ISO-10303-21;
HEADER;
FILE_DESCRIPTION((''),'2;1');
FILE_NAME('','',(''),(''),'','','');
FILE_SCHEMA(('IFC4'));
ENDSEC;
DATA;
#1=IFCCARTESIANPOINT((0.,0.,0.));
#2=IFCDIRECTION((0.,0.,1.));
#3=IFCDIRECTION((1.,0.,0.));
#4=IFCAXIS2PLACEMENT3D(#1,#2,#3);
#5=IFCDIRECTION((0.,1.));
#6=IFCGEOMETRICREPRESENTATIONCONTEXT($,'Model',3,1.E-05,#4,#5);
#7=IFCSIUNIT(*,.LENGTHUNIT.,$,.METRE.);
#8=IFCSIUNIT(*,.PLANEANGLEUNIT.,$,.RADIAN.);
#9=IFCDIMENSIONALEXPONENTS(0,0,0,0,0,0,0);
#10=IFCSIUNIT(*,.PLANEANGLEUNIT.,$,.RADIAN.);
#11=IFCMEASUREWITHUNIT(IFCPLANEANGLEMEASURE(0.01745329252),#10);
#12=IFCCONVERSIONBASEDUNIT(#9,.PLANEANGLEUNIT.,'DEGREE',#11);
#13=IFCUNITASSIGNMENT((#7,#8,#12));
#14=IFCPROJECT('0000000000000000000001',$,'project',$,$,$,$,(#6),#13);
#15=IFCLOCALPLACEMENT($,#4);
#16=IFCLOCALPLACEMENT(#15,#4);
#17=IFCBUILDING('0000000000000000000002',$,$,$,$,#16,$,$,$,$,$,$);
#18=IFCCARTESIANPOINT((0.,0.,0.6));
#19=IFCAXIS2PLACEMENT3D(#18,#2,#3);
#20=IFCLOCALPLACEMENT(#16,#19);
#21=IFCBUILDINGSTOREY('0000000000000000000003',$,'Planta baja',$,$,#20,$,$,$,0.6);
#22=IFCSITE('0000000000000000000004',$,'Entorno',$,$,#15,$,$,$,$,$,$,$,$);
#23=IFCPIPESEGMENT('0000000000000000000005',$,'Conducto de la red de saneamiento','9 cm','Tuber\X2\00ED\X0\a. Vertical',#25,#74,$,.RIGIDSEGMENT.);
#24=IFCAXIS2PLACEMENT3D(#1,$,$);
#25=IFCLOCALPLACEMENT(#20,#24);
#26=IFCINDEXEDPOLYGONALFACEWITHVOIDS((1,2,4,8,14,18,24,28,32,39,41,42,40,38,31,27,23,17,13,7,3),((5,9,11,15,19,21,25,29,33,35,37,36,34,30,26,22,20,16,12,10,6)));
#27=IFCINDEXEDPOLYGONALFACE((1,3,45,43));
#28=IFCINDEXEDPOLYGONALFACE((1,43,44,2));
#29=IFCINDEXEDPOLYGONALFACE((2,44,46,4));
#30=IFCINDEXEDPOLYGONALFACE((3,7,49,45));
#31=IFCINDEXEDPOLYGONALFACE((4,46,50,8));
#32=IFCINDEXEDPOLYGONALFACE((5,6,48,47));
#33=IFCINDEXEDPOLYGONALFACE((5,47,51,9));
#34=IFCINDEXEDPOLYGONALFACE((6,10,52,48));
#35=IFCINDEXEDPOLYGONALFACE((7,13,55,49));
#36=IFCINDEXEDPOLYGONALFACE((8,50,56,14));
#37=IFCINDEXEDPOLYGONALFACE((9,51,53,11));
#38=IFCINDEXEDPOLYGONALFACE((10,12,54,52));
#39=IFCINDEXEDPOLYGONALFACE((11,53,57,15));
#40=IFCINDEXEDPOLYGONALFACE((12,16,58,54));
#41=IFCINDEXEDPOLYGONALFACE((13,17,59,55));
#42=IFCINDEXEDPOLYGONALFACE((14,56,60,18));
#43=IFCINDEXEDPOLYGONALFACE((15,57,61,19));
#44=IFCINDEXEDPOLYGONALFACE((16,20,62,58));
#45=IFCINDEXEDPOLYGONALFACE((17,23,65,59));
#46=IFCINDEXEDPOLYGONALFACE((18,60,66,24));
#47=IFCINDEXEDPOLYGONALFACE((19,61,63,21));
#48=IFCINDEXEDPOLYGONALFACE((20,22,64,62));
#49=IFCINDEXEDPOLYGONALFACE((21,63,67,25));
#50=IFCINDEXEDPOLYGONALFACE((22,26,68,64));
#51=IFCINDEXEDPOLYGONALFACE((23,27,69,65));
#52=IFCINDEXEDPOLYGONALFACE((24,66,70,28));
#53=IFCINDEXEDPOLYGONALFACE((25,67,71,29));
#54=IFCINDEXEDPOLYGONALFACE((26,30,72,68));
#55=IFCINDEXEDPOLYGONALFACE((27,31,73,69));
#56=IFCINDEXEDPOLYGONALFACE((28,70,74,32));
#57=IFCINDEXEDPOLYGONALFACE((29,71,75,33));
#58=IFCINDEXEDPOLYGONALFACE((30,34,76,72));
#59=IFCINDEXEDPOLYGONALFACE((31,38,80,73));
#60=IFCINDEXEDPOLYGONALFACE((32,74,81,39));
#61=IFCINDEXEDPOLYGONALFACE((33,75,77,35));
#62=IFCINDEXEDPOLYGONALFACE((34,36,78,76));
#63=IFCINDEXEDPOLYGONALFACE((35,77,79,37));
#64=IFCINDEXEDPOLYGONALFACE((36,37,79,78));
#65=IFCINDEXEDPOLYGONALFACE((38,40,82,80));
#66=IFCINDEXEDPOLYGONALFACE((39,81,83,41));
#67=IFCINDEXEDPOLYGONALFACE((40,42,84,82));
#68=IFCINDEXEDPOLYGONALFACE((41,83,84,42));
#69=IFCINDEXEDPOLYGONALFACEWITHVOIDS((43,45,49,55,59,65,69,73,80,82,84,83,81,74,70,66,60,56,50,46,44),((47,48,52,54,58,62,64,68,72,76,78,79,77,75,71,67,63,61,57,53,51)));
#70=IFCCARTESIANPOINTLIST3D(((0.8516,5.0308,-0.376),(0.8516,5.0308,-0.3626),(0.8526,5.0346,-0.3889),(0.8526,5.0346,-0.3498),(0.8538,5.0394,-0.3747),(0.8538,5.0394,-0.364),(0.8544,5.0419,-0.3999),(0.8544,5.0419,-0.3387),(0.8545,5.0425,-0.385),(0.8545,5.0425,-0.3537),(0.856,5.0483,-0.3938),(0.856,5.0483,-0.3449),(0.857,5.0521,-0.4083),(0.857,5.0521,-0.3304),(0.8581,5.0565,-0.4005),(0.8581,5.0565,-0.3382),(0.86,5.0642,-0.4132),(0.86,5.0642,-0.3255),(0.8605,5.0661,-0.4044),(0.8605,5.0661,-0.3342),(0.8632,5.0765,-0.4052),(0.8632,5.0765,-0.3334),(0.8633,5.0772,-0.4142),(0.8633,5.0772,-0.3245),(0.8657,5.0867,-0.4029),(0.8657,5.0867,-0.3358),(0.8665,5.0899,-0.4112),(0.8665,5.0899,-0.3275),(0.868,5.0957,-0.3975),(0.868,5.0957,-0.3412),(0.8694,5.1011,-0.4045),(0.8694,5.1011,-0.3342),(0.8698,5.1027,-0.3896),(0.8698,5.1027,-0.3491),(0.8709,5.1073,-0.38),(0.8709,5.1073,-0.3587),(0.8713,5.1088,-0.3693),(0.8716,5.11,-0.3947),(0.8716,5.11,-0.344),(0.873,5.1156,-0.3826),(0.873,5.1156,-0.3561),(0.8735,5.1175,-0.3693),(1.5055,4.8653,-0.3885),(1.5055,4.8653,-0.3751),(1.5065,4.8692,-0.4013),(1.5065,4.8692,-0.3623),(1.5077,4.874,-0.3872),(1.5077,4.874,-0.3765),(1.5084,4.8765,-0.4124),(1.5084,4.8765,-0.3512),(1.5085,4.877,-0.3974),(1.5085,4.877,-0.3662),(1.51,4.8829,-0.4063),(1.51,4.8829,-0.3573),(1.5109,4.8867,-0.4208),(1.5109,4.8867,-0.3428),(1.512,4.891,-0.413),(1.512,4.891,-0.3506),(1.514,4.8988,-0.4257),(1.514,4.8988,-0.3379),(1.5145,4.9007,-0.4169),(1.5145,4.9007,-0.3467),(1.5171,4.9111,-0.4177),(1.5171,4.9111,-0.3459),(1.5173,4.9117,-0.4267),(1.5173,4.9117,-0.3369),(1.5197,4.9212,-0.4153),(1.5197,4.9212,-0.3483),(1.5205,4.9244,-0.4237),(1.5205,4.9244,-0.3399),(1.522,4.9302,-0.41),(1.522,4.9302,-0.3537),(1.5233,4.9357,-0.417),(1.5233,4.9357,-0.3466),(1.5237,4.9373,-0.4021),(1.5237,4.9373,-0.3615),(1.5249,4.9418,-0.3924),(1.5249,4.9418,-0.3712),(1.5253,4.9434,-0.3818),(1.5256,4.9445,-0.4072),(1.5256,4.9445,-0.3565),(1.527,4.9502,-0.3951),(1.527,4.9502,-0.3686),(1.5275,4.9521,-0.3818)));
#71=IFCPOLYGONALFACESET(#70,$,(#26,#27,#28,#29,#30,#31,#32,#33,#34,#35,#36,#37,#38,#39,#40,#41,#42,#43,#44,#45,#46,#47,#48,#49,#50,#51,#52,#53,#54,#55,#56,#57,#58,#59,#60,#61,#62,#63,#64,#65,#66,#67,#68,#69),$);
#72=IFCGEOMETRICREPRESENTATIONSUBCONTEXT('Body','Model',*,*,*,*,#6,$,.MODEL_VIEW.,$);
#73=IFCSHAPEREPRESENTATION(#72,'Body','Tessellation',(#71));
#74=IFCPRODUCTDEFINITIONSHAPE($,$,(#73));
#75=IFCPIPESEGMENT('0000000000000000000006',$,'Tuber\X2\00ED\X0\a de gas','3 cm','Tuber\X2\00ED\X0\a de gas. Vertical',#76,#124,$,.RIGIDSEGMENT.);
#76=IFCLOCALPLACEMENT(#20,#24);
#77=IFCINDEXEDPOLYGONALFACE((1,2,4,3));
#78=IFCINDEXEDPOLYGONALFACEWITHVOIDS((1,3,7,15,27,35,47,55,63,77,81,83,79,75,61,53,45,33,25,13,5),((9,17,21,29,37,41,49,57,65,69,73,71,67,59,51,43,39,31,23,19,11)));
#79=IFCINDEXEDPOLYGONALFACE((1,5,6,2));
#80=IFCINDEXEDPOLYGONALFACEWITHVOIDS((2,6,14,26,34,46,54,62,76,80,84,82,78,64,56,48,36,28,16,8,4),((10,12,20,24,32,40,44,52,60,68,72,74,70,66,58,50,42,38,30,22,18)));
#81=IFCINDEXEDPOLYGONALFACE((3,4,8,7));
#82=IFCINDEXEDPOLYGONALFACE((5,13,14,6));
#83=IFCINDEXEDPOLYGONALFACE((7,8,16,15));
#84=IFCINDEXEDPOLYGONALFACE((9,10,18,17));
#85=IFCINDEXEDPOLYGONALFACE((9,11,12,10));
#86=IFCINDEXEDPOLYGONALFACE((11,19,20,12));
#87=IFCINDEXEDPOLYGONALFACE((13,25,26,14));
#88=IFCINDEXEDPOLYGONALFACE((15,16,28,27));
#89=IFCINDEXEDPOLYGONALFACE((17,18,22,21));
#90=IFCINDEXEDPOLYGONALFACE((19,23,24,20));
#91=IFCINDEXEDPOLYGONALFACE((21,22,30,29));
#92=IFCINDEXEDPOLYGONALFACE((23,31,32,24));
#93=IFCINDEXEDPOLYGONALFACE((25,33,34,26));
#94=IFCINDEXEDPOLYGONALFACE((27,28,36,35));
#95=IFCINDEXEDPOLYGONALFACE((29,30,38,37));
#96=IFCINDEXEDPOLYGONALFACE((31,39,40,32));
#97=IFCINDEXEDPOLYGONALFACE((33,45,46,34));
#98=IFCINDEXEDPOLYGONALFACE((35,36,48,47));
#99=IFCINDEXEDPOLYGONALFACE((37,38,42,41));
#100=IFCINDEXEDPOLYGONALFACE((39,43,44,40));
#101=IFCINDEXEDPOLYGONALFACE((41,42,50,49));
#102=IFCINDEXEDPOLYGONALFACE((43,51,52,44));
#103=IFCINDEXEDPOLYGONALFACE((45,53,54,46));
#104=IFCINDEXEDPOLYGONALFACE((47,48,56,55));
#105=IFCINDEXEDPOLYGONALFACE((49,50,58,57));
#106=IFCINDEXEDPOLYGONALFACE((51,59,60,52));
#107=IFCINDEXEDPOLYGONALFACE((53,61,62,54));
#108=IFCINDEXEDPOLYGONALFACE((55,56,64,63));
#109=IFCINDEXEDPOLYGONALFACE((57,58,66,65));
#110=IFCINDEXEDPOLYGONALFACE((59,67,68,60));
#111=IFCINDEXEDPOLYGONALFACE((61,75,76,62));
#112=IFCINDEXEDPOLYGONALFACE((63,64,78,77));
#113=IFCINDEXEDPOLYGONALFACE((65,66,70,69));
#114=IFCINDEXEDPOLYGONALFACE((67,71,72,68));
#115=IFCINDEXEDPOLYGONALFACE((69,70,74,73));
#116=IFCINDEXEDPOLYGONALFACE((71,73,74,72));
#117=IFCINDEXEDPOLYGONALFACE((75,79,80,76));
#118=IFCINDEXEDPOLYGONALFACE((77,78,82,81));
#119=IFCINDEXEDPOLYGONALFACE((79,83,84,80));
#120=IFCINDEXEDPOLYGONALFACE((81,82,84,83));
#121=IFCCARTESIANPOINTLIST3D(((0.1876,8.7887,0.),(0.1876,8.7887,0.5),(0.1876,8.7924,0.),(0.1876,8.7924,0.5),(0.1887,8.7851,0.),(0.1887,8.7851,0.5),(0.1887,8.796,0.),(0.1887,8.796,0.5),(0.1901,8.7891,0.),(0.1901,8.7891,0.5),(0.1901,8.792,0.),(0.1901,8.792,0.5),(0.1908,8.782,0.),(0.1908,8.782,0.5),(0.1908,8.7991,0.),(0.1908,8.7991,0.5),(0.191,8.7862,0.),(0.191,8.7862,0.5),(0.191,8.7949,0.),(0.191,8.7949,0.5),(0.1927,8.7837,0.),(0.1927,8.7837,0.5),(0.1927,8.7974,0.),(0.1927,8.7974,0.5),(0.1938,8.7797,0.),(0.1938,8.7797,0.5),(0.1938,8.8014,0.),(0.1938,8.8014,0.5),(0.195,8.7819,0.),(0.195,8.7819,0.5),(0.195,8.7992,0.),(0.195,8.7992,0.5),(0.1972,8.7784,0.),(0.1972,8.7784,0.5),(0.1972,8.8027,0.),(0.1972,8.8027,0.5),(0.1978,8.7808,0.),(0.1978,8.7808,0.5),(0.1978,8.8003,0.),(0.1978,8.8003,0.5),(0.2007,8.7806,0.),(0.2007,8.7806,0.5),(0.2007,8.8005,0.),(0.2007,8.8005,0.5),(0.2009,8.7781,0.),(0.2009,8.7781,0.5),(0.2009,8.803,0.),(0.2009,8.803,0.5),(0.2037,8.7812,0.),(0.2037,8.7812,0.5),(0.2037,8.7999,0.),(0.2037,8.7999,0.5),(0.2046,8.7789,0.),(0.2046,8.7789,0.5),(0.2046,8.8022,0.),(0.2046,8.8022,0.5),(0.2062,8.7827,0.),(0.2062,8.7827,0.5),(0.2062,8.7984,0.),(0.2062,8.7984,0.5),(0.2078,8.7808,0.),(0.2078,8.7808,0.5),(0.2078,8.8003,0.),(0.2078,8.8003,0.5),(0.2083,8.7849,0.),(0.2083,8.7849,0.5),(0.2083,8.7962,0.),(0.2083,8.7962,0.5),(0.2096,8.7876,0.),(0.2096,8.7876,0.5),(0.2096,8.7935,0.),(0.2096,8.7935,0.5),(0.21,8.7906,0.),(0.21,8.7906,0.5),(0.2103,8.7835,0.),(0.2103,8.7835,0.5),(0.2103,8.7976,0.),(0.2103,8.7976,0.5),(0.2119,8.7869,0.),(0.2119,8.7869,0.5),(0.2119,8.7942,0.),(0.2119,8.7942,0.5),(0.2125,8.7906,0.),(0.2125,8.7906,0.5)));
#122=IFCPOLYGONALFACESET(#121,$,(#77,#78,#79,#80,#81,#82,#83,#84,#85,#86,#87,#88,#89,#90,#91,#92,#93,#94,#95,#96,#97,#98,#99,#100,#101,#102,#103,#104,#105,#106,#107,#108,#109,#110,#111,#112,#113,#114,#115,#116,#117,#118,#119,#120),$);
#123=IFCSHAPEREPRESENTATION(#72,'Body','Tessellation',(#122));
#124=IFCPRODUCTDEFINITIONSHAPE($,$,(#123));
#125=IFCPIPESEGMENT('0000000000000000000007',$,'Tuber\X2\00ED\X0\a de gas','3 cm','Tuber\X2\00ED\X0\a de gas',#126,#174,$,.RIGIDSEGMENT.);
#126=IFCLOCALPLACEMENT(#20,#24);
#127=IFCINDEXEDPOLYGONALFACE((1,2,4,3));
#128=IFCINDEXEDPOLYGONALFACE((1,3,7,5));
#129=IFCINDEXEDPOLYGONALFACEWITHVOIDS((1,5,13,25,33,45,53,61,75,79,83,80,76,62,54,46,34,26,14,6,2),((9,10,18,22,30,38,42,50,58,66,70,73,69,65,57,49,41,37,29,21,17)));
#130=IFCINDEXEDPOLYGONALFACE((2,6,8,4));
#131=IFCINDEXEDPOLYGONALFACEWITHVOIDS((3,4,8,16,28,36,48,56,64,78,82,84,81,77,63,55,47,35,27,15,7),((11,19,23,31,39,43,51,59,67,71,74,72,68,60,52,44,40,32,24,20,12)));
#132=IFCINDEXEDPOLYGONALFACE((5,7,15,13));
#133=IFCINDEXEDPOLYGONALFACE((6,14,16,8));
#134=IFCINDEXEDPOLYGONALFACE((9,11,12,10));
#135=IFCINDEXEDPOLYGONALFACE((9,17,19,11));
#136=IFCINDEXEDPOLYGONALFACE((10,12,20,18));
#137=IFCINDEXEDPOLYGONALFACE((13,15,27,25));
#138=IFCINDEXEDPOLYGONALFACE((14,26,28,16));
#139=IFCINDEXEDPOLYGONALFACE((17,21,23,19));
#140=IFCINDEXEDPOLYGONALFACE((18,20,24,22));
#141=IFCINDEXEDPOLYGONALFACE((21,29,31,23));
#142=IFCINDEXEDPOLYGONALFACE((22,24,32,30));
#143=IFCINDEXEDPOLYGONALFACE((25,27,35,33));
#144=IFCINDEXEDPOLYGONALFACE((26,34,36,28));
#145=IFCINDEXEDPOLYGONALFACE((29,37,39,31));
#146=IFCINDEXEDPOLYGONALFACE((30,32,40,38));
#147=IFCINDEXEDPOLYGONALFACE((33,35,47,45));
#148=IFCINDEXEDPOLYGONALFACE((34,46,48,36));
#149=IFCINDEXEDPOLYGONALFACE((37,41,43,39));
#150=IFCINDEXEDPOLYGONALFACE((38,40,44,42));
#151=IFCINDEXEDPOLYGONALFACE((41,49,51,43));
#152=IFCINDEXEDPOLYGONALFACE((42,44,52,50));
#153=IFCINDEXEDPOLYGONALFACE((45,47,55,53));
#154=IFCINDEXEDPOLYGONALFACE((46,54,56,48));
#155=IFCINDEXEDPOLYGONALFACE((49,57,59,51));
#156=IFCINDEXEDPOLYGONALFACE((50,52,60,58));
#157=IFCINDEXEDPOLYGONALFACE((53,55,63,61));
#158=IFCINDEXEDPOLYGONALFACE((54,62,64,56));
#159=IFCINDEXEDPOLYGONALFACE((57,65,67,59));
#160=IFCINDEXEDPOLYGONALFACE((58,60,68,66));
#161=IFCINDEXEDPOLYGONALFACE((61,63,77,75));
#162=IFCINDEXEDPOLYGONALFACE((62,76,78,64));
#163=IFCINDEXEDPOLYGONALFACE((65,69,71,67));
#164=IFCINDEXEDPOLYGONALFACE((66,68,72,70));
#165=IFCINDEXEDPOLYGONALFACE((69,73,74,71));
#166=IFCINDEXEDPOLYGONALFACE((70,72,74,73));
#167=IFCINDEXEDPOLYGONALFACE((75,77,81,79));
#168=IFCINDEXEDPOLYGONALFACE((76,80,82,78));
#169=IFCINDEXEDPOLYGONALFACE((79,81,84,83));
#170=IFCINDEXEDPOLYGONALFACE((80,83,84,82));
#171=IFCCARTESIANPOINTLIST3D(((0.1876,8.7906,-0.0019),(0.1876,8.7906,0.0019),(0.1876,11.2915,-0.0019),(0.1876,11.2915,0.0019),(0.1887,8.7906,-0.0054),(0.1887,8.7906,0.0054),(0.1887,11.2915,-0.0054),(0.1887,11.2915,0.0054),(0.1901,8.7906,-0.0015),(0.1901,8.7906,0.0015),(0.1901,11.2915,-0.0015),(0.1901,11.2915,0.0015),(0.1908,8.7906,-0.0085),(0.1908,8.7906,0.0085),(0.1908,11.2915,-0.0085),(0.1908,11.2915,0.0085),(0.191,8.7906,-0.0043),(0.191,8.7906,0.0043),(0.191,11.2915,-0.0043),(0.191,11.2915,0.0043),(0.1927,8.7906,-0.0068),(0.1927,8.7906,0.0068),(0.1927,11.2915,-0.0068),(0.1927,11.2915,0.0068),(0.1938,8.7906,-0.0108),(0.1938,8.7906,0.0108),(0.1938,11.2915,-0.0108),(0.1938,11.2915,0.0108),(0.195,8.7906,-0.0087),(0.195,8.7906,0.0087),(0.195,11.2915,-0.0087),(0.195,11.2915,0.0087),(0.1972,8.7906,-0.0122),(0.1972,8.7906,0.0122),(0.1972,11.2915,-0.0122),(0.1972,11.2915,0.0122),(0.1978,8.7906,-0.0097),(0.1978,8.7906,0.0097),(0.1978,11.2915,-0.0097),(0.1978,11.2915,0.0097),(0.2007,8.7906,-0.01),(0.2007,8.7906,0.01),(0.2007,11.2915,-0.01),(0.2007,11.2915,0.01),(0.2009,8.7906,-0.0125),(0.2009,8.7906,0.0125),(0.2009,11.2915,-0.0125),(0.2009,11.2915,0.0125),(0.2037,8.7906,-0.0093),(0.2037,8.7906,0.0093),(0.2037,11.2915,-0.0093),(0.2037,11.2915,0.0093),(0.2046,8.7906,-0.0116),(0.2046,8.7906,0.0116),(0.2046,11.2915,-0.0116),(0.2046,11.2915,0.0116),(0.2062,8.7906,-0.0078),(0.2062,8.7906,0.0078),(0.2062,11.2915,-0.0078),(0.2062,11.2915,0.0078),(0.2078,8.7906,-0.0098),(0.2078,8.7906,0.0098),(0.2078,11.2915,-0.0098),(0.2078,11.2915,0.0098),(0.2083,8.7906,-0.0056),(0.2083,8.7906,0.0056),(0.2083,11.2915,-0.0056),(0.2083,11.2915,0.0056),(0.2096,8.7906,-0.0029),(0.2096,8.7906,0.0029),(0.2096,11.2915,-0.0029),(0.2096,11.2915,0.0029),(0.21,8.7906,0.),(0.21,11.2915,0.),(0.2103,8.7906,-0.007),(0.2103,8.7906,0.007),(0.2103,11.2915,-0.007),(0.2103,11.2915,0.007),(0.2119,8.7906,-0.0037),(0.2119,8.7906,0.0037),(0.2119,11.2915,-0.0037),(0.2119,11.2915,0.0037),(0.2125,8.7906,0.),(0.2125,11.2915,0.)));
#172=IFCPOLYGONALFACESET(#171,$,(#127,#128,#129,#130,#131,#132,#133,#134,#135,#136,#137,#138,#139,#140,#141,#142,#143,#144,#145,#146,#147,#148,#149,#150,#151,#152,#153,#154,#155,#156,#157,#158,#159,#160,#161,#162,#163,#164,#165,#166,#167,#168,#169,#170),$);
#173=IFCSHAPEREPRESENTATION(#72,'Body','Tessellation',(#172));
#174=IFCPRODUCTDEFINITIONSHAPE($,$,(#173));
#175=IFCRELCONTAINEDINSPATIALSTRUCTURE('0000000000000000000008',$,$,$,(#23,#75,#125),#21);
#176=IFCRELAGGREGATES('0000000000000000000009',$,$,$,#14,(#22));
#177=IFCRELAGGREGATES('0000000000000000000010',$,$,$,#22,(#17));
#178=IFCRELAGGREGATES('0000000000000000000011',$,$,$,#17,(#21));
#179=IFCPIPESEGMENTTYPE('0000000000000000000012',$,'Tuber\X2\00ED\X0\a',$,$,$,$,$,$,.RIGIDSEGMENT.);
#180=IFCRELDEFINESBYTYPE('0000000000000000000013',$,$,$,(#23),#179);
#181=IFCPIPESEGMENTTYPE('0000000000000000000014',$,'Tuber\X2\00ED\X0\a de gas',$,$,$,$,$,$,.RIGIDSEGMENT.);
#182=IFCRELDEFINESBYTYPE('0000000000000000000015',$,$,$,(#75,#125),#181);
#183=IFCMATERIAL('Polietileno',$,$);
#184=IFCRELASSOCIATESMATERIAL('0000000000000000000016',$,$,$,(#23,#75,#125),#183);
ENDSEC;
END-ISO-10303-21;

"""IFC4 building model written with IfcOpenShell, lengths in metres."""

from ifc_helpers import new_model, entity, si_unit, converted_unit, direction, frame, origin_with_axes, origin_2d_with_axis, place, context, subcontext, project, spatial, hollow_circle, extrude, material, type_object, element, save


model = new_model("IFC4")

# Units and contexts
model_context = context("Model", 3, precision=1e-05, world=origin_with_axes(), true_north=direction((0.0, 1.0)))
body_context = subcontext(model_context, "Body", "Model", "MODEL_VIEW")
ifc_project = project(units=[si_unit("LENGTHUNIT", "METRE"), si_unit("PLANEANGLEUNIT", "RADIAN"), converted_unit("PLANEANGLEUNIT", "DEGREE", entity("IfcPlaneAngleMeasure", 0.01745329252), si_unit("PLANEANGLEUNIT", "RADIAN"), dimensions=[0, 0, 0, 0, 0, 0, 0])], contexts=[model_context])

# Site, building, storey
site_placement = place(None, origin_with_axes())
site = spatial("IfcSite", under=ifc_project, at=site_placement, Name="Entorno")
building_placement = place(site_placement, origin_with_axes())
building = spatial("IfcBuilding", under=site, at=building_placement)
storey_placement = place(building_placement, frame((0.0, 0.0, 0.6), z_axis=(0.0, 0.0, 1.0), x_axis=(1.0, 0.0, 0.0)))
storey = spatial("IfcBuildingStorey", under=building, at=storey_placement, Name="Planta baja", Elevation=0.6)

# Pipe segments
ifc_material_1 = material(Name="Polietileno")
pipe_segment_type_1 = type_object("IfcPipeSegmentType", Name="Tubería", PredefinedType="RIGIDSEGMENT")
pipe_segment_1_placement = place(storey_placement, frame((0.8625, 5.0739, -0.3693), z_axis=(0.969462, -0.245241, 0.0), x_axis=(0.245241, 0.969462, 0.0)))
element("IfcPipeSegment", 1, at=pipe_segment_1_placement, inside=storey, type_object=pipe_segment_type_1, material=ifc_material_1, Name="Conducto de la red de saneamiento", Description="9 cm", ObjectType="Tubería. Vertical", PredefinedType="RIGIDSEGMENT", context=body_context, shape_type="SweptSolid", body=[
    extrude(hollow_circle(Radius=0.045, WallThickness=0.009, at=origin_2d_with_axis()), origin_with_axes(), (0.0, -0.018497, 0.999829), 0.6747),
])
pipe_segment_type_2 = type_object("IfcPipeSegmentType", Name="Tubería de gas", PredefinedType="RIGIDSEGMENT")
pipe_segment_2_placement = place(storey_placement, frame((0.2, 8.7906, 0.0), z_axis=(0.0, 0.0, 1.0), x_axis=(1.0, 0.0, 0.0)))
element("IfcPipeSegment", 2, at=pipe_segment_2_placement, inside=storey, type_object=pipe_segment_type_2, material=ifc_material_1, Name="Tubería de gas", Description="3 cm", ObjectType="Tubería de gas. Vertical", PredefinedType="RIGIDSEGMENT", context=body_context, shape_type="SweptSolid", body=[
    extrude(hollow_circle(Radius=0.0125, WallThickness=0.0025, at=origin_2d_with_axis()), origin_with_axes(), (0.0, 0.0, 1.0), 0.5),
])
pipe_segment_3_placement = place(storey_placement, frame((0.2, 11.2915, 0.0), z_axis=(0.0, -1.0, 0.0), x_axis=(1.0, 0.0, 0.0)))
element("IfcPipeSegment", 3, at=pipe_segment_3_placement, inside=storey, type_object=pipe_segment_type_2, material=ifc_material_1, Name="Tubería de gas", Description="3 cm", ObjectType="Tubería de gas", PredefinedType="RIGIDSEGMENT", context=body_context, shape_type="SweptSolid", body=[
    extrude(hollow_circle(Radius=0.0125, WallThickness=0.0025, at=origin_2d_with_axis()), origin_with_axes(), (0.0, 0.0, 1.0), 2.5009),
])

save(model, "model.ifc")
